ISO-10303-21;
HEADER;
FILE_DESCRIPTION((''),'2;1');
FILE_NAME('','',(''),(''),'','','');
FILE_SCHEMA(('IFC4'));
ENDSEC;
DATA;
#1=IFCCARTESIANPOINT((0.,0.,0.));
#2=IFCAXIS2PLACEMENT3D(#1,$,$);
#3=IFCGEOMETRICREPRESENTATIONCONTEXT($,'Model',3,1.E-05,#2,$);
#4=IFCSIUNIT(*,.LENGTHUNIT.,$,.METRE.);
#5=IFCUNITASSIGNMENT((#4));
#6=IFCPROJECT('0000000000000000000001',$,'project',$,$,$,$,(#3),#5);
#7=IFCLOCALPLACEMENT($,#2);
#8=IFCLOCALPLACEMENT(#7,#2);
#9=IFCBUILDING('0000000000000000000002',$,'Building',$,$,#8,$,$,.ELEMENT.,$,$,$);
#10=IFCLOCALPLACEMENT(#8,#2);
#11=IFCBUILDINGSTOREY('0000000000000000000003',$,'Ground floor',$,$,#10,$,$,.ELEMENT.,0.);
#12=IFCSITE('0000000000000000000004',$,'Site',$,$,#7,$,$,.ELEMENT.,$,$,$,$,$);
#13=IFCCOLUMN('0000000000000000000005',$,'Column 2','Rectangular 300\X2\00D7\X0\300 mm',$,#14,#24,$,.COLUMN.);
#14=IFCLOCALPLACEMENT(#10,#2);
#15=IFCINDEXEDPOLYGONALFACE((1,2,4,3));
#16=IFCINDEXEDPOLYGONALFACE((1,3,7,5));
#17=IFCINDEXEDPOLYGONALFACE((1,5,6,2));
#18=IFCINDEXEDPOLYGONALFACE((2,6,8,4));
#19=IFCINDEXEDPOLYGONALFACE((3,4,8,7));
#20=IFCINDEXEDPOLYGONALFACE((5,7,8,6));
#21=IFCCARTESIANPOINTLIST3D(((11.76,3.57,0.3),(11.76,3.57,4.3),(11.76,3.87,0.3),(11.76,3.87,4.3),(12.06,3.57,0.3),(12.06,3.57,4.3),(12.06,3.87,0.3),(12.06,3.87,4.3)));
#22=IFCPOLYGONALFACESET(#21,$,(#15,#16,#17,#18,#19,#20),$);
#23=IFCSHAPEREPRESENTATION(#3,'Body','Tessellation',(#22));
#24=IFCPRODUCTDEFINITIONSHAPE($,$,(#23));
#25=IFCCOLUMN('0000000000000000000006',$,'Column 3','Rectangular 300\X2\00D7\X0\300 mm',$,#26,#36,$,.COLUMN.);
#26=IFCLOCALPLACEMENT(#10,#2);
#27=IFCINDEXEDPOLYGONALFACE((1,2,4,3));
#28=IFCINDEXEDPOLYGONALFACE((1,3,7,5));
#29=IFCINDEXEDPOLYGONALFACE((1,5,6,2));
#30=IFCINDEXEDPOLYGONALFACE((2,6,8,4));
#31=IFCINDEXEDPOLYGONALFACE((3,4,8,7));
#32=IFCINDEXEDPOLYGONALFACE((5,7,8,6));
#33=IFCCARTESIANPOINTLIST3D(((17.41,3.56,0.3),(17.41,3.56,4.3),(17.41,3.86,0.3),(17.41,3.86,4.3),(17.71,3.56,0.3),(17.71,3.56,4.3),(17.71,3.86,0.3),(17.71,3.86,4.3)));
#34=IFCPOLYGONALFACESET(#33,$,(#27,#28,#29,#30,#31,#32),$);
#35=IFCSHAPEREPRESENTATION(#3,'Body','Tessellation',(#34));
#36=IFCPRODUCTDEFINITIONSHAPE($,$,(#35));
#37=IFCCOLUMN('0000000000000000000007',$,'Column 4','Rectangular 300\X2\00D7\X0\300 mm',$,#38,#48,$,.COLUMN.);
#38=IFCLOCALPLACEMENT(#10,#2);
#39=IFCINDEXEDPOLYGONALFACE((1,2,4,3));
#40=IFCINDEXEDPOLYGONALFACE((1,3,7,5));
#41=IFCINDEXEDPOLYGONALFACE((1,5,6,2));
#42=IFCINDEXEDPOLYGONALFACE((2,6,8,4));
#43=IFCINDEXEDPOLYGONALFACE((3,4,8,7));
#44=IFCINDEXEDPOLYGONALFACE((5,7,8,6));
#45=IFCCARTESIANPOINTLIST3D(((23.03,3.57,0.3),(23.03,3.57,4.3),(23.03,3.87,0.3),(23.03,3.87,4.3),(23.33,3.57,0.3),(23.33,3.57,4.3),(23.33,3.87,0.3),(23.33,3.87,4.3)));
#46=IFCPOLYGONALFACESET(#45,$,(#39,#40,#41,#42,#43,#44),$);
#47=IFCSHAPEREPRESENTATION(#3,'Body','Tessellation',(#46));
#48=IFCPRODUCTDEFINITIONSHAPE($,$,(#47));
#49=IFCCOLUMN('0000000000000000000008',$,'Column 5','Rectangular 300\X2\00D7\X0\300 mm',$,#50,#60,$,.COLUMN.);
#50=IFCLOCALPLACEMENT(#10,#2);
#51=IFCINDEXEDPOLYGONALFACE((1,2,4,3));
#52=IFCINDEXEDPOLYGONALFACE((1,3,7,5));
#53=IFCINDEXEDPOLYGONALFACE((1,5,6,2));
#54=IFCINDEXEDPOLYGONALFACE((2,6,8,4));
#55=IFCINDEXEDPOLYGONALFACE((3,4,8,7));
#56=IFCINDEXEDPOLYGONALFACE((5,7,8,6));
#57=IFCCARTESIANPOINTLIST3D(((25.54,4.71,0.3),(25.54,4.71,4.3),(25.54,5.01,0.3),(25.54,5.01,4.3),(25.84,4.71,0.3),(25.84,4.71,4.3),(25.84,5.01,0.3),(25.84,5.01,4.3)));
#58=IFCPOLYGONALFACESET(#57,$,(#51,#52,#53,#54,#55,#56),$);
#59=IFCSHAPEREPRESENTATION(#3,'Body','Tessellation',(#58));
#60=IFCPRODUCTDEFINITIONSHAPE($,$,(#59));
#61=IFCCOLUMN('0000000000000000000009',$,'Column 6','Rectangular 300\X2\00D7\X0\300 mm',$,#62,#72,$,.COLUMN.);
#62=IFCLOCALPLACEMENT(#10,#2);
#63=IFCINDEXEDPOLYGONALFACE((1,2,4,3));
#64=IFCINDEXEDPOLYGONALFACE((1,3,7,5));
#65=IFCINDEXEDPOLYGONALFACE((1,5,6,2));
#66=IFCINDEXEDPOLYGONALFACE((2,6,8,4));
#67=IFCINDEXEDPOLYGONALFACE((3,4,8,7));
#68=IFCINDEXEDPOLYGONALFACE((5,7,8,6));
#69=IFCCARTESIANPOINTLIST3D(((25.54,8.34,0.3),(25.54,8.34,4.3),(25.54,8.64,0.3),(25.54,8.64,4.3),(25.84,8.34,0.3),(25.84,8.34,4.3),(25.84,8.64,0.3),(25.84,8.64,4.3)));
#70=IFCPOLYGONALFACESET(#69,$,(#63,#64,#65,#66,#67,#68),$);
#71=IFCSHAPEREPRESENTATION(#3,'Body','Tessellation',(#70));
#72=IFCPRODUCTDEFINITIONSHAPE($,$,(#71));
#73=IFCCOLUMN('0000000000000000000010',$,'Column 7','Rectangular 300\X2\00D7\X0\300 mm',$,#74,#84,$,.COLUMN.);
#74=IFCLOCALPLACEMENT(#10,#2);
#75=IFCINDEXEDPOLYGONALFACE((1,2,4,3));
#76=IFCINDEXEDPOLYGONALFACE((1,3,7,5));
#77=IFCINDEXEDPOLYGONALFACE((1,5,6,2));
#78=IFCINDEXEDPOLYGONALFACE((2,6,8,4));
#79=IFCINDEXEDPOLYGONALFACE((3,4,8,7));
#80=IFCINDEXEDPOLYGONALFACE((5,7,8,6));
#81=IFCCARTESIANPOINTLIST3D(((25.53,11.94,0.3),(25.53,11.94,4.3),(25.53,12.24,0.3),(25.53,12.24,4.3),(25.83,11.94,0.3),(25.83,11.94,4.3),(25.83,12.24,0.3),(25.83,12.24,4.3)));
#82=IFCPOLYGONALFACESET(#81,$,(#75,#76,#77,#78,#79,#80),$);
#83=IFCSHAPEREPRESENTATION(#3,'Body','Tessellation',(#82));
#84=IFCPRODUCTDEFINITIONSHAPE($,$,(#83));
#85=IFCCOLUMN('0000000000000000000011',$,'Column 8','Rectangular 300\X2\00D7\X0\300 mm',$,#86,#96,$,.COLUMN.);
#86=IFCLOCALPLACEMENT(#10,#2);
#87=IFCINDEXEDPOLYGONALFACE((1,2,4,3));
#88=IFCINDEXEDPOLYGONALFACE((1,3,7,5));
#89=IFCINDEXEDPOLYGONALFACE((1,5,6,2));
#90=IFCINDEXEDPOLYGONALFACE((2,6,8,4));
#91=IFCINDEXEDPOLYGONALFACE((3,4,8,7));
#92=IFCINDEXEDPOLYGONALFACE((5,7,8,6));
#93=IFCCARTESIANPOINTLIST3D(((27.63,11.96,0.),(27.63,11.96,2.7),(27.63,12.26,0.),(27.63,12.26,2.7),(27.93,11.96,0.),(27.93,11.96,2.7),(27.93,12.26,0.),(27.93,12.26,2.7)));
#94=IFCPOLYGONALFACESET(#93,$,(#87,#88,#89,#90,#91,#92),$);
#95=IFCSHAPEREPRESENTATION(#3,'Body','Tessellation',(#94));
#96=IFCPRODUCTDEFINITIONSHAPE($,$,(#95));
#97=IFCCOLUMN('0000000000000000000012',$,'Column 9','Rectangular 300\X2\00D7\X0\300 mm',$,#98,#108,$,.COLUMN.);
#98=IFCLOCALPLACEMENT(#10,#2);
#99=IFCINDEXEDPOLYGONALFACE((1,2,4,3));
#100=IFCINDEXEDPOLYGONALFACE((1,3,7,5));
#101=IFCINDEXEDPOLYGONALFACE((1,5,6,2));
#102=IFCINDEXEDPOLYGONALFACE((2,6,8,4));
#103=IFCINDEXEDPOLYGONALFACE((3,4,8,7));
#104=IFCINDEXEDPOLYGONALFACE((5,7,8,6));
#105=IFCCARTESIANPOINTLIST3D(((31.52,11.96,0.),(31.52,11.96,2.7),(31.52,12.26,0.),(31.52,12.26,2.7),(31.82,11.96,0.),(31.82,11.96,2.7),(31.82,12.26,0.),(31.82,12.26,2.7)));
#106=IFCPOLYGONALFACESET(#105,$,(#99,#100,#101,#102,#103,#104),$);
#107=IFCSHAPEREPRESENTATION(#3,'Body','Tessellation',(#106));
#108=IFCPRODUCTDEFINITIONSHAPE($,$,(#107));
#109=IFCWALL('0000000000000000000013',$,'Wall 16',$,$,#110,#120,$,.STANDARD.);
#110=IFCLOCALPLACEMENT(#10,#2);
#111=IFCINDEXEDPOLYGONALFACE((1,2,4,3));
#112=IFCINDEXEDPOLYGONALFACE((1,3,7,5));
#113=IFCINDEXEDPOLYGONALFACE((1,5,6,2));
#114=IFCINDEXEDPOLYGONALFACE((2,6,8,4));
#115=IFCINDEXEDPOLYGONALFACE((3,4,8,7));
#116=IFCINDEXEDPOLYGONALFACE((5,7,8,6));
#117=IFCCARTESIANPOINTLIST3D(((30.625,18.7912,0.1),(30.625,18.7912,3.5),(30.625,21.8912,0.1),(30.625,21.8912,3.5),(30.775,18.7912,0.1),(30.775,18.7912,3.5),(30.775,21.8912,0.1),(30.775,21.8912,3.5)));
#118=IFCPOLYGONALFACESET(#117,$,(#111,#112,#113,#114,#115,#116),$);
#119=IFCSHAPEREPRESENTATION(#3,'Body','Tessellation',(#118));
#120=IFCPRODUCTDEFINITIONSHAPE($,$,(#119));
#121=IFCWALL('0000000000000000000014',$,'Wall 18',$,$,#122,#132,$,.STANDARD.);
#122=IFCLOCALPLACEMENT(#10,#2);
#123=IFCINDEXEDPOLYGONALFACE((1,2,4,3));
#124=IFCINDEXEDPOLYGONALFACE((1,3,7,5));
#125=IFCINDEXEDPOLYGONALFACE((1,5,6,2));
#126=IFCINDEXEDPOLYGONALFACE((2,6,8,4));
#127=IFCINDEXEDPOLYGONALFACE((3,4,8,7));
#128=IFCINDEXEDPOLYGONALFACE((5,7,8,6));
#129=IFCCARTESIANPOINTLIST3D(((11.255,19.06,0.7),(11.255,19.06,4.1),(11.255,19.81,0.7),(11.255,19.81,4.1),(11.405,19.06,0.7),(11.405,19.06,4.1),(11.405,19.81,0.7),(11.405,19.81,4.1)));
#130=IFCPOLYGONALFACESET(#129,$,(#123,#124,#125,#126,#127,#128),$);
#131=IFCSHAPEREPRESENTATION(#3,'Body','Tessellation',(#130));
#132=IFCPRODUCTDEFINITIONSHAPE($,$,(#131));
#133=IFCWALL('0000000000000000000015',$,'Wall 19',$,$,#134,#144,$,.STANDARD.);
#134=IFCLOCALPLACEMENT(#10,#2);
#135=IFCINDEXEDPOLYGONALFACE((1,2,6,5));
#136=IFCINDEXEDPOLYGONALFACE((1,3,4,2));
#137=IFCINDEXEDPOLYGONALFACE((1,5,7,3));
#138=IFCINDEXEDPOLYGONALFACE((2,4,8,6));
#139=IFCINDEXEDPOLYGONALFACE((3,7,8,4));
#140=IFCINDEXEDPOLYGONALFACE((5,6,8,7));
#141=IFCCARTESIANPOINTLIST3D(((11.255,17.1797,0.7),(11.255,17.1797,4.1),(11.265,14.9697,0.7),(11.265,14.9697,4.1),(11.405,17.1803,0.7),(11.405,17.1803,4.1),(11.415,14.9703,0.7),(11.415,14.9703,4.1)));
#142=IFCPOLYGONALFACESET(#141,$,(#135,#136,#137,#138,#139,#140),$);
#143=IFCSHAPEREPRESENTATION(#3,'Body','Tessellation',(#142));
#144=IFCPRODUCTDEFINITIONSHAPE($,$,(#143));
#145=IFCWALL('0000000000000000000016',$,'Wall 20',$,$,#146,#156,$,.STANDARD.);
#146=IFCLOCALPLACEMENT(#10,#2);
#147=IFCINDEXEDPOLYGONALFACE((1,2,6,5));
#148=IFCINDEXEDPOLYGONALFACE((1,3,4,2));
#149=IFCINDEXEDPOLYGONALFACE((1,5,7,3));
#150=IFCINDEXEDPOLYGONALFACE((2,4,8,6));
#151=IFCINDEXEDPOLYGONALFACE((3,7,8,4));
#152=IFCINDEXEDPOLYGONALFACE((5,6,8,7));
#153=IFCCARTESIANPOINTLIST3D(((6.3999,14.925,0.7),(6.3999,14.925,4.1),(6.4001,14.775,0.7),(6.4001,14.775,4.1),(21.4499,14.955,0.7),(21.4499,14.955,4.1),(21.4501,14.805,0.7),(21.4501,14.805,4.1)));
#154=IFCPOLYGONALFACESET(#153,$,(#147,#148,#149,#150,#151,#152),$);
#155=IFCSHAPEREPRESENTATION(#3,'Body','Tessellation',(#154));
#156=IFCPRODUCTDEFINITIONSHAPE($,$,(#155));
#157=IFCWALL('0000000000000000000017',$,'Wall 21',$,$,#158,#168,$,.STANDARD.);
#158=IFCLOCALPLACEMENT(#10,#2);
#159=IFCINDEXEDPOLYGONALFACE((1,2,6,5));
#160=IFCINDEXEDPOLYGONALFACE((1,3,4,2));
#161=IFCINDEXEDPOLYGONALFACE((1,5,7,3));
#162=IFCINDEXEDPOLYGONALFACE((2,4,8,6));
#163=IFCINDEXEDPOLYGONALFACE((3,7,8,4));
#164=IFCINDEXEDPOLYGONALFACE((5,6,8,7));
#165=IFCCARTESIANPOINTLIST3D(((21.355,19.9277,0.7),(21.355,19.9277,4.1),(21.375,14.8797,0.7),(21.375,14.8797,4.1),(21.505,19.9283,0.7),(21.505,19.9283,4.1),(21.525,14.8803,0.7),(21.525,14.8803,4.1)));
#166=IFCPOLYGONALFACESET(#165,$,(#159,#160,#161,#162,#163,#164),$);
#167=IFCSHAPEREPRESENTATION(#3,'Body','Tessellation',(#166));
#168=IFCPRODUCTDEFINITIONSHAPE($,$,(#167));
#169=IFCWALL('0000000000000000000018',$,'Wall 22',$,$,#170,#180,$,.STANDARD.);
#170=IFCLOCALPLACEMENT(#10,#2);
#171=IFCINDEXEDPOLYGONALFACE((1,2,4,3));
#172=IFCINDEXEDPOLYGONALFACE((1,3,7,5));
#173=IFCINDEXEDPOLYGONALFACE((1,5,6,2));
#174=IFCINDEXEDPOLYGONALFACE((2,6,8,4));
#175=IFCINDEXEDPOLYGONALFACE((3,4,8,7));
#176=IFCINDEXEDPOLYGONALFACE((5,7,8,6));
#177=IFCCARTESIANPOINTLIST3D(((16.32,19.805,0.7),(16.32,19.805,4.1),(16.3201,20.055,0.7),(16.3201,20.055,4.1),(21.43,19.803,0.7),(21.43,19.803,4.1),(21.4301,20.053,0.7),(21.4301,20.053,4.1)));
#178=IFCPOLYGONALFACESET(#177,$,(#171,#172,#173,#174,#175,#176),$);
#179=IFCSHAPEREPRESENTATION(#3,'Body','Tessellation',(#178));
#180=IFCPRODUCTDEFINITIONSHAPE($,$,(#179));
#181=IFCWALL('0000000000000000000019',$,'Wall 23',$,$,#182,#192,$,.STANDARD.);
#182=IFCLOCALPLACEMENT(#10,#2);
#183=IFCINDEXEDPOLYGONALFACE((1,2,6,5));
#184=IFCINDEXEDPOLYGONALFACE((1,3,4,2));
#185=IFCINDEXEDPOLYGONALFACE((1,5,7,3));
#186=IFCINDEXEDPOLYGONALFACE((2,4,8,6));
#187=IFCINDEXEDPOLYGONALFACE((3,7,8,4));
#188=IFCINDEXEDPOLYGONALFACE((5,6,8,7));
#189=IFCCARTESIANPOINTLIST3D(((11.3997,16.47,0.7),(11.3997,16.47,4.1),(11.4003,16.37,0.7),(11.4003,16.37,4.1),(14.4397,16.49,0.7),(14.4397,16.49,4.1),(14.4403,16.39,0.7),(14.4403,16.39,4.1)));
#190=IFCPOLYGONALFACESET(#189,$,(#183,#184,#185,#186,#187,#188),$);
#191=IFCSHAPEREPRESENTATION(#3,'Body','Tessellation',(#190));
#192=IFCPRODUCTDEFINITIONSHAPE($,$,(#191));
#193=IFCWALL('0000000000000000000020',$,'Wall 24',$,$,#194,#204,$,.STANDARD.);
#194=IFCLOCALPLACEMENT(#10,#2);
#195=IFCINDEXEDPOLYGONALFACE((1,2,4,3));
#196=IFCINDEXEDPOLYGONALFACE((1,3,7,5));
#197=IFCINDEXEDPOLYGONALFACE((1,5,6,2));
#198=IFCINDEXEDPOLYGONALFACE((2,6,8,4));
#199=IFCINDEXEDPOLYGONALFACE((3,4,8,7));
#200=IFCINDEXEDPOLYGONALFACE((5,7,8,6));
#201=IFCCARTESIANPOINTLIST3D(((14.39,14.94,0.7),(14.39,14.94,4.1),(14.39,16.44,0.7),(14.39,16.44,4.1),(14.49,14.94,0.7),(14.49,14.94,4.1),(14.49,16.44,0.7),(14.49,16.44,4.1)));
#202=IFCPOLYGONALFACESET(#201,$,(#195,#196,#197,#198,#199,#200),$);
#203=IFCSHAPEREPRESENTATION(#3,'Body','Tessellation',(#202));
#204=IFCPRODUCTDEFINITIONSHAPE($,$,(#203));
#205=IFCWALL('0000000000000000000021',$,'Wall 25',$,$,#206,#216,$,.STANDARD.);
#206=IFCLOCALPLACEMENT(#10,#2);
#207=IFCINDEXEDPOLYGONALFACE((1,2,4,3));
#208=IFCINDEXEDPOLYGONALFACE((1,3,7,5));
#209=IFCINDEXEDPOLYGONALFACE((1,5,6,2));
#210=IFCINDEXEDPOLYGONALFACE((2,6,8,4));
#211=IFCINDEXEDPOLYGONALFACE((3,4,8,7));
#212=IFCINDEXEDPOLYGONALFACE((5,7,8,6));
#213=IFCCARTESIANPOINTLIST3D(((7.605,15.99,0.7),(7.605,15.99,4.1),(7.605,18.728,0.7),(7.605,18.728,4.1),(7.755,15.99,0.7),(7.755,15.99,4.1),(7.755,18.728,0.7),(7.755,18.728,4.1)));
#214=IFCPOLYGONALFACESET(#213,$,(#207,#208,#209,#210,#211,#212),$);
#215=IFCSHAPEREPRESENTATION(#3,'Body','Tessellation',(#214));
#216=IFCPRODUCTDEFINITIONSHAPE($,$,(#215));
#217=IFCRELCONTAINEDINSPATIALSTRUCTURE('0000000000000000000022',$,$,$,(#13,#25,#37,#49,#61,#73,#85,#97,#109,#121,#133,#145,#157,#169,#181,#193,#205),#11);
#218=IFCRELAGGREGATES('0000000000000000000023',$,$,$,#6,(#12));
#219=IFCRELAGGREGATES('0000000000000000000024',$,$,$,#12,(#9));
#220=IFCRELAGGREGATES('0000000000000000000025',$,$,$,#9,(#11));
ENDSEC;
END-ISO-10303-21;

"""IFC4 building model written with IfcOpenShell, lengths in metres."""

from ifc_helpers import new_model, si_unit, frame, frame_2d, origin, place, context, project, spatial, polyline, rectangle, outline, extrude, element, save


model = new_model("IFC4")

# Units and contexts
model_context = context("Model", 3, precision=1e-05, world=origin())
ifc_project = project(units=[si_unit("LENGTHUNIT", "METRE")], contexts=[model_context])

# Site, building, storey
site_placement = place(None, origin())
site = spatial("IfcSite", under=ifc_project, at=site_placement, Name="Site", CompositionType="ELEMENT")
building_placement = place(site_placement, origin())
building = spatial("IfcBuilding", under=site, at=building_placement, Name="Building", CompositionType="ELEMENT")
storey_placement = place(building_placement, origin())
storey = spatial("IfcBuildingStorey", under=building, at=storey_placement, Name="Ground floor", CompositionType="ELEMENT", Elevation=0.0)

# Columns
for number, where, z_axis, x_axis, name in (
    (1, (11.91, 3.72, 0.3), (0.0, 0.0, 1.0), (1.0, 0.0, 0.0), "Column 2"),
    (2, (17.56, 3.71, 0.3), (0.0, 0.0, 1.0), (1.0, 0.0, 0.0), "Column 3"),
    (3, (23.18, 3.72, 0.3), (0.0, 0.0, 1.0), (1.0, 0.0, 0.0), "Column 4"),
    (4, (25.69, 4.86, 0.3), (0.0, 0.0, 1.0), (1.0, 0.0, 0.0), "Column 5"),
    (5, (25.69, 8.49, 0.3), (0.0, 0.0, 1.0), (1.0, 0.0, 0.0), "Column 6"),
    (6, (25.68, 12.09, 0.3), (0.0, 0.0, 1.0), (1.0, 0.0, 0.0), "Column 7"),
):
    element("IfcColumn", number, at=place(storey_placement, frame(where, z_axis=z_axis, x_axis=x_axis)), inside=storey, Name=name, Description="Rectangular 300×300 mm", PredefinedType="COLUMN", context=model_context, shape_type="SweptSolid", body=[
        extrude(outline(polyline([(-0.15, -0.15), (0.15, -0.15), (0.15, 0.15), (-0.15, 0.15), (-0.15, -0.15)])), origin(), (0.0, 0.0, 1.0), 4.0),
    ])
for number, where, z_axis, x_axis, name in (
    (7, (27.78, 12.11, 0.0), (0.0, 0.0, 1.0), (1.0, 0.0, 0.0), "Column 8"),
    (8, (31.67, 12.11, 0.0), (0.0, 0.0, 1.0), (1.0, 0.0, 0.0), "Column 9"),
):
    element("IfcColumn", number, at=place(storey_placement, frame(where, z_axis=z_axis, x_axis=x_axis)), inside=storey, Name=name, Description="Rectangular 300×300 mm", PredefinedType="COLUMN", context=model_context, shape_type="SweptSolid", body=[
        extrude(outline(polyline([(-0.15, -0.15), (0.15, -0.15), (0.15, 0.15), (-0.15, 0.15), (-0.15, -0.15)])), origin(), (0.0, 0.0, 1.0), 2.7),
    ])

# Walls
wall_1_placement = place(storey_placement, frame((30.7, 18.7912, 0.1), z_axis=(0.0, 0.0, 1.0), x_axis=(0.0, 1.0, 0.0)))
element("IfcWall", 9, at=wall_1_placement, inside=storey, Name="Wall 16", PredefinedType="STANDARD", context=model_context, shape_type="SweptSolid", body=[
    extrude(rectangle(XDim=3.1, YDim=0.15, at=frame_2d((1.55, 0.0))), origin(), (0.0, 0.0, 1.0), 3.4),
])
wall_2_placement = place(storey_placement, frame((11.33, 19.06, 0.7), z_axis=(0.0, 0.0, 1.0), x_axis=(0.0, 1.0, 0.0)))
element("IfcWall", 10, at=wall_2_placement, inside=storey, Name="Wall 18", PredefinedType="STANDARD", context=model_context, shape_type="SweptSolid", body=[
    extrude(rectangle(XDim=0.75, YDim=0.15, at=frame_2d((0.375, 0.0))), origin(), (0.0, 0.0, 1.0), 3.4),
])
wall_3_placement = place(storey_placement, frame((11.34, 14.97, 0.7), z_axis=(0.0, 0.0, 1.0), x_axis=(-0.004525, 0.99999, 0.0)))
element("IfcWall", 11, at=wall_3_placement, inside=storey, Name="Wall 19", PredefinedType="STANDARD", context=model_context, shape_type="SweptSolid", body=[
    extrude(rectangle(XDim=2.21, YDim=0.15, at=frame_2d((1.105, 0.0))), origin(), (0.0, 0.0, 1.0), 3.4),
])
wall_4_placement = place(storey_placement, frame((21.45, 14.88, 0.7), z_axis=(0.0, 0.0, 1.0), x_axis=(-0.999998, -0.001993, 0.0)))
element("IfcWall", 12, at=wall_4_placement, inside=storey, Name="Wall 20", PredefinedType="STANDARD", context=model_context, shape_type="SweptSolid", body=[
    extrude(rectangle(XDim=15.05, YDim=0.15, at=frame_2d((7.525, 0.0))), origin(), (0.0, 0.0, 1.0), 3.4),
])
wall_5_placement = place(storey_placement, frame((21.45, 14.88, 0.7), z_axis=(0.0, 0.0, 1.0), x_axis=(-0.003961, 0.999992, 0.0)))
element("IfcWall", 13, at=wall_5_placement, inside=storey, Name="Wall 21", PredefinedType="STANDARD", context=model_context, shape_type="SweptSolid", body=[
    extrude(rectangle(XDim=5.048, YDim=0.15, at=frame_2d((2.524, 0.0))), origin(), (0.0, 0.0, 1.0), 3.4),
])
wall_6_placement = place(storey_placement, frame((16.32, 19.93, 0.7), z_axis=(0.0, 0.0, 1.0), x_axis=(1.0, -0.000398, 0.0)))
element("IfcWall", 14, at=wall_6_placement, inside=storey, Name="Wall 22", PredefinedType="STANDARD", context=model_context, shape_type="SweptSolid", body=[
    extrude(rectangle(XDim=5.11, YDim=0.25, at=frame_2d((2.555, 0.0))), origin(), (0.0, 0.0, 1.0), 3.4),
])
wall_7_placement = place(storey_placement, frame((11.4, 16.42, 0.7), z_axis=(0.0, 0.0, 1.0), x_axis=(0.999978, 0.006579, 0.0)))
element("IfcWall", 15, at=wall_7_placement, inside=storey, Name="Wall 23", PredefinedType="STANDARD", context=model_context, shape_type="SweptSolid", body=[
    extrude(rectangle(XDim=3.0401, YDim=0.1, at=frame_2d((1.52, 0.0))), origin(), (0.0, 0.0, 1.0), 3.4),
])
wall_8_placement = place(storey_placement, frame((14.44, 14.94, 0.7), z_axis=(0.0, 0.0, 1.0), x_axis=(0.0, 1.0, 0.0)))
element("IfcWall", 16, at=wall_8_placement, inside=storey, Name="Wall 24", PredefinedType="STANDARD", context=model_context, shape_type="SweptSolid", body=[
    extrude(rectangle(XDim=1.5, YDim=0.1, at=frame_2d((0.75, 0.0))), origin(), (0.0, 0.0, 1.0), 3.4),
])
wall_9_placement = place(storey_placement, frame((7.68, 15.99, 0.7), z_axis=(0.0, 0.0, 1.0), x_axis=(0.000002, 1.0, 0.0)))
element("IfcWall", 17, at=wall_9_placement, inside=storey, Name="Wall 25", PredefinedType="STANDARD", context=model_context, shape_type="SweptSolid", body=[
    extrude(rectangle(XDim=2.738, YDim=0.15, at=frame_2d((1.369, 0.0))), origin(), (0.0, 0.0, 1.0), 3.4),
])

save(model, "model.ifc")
